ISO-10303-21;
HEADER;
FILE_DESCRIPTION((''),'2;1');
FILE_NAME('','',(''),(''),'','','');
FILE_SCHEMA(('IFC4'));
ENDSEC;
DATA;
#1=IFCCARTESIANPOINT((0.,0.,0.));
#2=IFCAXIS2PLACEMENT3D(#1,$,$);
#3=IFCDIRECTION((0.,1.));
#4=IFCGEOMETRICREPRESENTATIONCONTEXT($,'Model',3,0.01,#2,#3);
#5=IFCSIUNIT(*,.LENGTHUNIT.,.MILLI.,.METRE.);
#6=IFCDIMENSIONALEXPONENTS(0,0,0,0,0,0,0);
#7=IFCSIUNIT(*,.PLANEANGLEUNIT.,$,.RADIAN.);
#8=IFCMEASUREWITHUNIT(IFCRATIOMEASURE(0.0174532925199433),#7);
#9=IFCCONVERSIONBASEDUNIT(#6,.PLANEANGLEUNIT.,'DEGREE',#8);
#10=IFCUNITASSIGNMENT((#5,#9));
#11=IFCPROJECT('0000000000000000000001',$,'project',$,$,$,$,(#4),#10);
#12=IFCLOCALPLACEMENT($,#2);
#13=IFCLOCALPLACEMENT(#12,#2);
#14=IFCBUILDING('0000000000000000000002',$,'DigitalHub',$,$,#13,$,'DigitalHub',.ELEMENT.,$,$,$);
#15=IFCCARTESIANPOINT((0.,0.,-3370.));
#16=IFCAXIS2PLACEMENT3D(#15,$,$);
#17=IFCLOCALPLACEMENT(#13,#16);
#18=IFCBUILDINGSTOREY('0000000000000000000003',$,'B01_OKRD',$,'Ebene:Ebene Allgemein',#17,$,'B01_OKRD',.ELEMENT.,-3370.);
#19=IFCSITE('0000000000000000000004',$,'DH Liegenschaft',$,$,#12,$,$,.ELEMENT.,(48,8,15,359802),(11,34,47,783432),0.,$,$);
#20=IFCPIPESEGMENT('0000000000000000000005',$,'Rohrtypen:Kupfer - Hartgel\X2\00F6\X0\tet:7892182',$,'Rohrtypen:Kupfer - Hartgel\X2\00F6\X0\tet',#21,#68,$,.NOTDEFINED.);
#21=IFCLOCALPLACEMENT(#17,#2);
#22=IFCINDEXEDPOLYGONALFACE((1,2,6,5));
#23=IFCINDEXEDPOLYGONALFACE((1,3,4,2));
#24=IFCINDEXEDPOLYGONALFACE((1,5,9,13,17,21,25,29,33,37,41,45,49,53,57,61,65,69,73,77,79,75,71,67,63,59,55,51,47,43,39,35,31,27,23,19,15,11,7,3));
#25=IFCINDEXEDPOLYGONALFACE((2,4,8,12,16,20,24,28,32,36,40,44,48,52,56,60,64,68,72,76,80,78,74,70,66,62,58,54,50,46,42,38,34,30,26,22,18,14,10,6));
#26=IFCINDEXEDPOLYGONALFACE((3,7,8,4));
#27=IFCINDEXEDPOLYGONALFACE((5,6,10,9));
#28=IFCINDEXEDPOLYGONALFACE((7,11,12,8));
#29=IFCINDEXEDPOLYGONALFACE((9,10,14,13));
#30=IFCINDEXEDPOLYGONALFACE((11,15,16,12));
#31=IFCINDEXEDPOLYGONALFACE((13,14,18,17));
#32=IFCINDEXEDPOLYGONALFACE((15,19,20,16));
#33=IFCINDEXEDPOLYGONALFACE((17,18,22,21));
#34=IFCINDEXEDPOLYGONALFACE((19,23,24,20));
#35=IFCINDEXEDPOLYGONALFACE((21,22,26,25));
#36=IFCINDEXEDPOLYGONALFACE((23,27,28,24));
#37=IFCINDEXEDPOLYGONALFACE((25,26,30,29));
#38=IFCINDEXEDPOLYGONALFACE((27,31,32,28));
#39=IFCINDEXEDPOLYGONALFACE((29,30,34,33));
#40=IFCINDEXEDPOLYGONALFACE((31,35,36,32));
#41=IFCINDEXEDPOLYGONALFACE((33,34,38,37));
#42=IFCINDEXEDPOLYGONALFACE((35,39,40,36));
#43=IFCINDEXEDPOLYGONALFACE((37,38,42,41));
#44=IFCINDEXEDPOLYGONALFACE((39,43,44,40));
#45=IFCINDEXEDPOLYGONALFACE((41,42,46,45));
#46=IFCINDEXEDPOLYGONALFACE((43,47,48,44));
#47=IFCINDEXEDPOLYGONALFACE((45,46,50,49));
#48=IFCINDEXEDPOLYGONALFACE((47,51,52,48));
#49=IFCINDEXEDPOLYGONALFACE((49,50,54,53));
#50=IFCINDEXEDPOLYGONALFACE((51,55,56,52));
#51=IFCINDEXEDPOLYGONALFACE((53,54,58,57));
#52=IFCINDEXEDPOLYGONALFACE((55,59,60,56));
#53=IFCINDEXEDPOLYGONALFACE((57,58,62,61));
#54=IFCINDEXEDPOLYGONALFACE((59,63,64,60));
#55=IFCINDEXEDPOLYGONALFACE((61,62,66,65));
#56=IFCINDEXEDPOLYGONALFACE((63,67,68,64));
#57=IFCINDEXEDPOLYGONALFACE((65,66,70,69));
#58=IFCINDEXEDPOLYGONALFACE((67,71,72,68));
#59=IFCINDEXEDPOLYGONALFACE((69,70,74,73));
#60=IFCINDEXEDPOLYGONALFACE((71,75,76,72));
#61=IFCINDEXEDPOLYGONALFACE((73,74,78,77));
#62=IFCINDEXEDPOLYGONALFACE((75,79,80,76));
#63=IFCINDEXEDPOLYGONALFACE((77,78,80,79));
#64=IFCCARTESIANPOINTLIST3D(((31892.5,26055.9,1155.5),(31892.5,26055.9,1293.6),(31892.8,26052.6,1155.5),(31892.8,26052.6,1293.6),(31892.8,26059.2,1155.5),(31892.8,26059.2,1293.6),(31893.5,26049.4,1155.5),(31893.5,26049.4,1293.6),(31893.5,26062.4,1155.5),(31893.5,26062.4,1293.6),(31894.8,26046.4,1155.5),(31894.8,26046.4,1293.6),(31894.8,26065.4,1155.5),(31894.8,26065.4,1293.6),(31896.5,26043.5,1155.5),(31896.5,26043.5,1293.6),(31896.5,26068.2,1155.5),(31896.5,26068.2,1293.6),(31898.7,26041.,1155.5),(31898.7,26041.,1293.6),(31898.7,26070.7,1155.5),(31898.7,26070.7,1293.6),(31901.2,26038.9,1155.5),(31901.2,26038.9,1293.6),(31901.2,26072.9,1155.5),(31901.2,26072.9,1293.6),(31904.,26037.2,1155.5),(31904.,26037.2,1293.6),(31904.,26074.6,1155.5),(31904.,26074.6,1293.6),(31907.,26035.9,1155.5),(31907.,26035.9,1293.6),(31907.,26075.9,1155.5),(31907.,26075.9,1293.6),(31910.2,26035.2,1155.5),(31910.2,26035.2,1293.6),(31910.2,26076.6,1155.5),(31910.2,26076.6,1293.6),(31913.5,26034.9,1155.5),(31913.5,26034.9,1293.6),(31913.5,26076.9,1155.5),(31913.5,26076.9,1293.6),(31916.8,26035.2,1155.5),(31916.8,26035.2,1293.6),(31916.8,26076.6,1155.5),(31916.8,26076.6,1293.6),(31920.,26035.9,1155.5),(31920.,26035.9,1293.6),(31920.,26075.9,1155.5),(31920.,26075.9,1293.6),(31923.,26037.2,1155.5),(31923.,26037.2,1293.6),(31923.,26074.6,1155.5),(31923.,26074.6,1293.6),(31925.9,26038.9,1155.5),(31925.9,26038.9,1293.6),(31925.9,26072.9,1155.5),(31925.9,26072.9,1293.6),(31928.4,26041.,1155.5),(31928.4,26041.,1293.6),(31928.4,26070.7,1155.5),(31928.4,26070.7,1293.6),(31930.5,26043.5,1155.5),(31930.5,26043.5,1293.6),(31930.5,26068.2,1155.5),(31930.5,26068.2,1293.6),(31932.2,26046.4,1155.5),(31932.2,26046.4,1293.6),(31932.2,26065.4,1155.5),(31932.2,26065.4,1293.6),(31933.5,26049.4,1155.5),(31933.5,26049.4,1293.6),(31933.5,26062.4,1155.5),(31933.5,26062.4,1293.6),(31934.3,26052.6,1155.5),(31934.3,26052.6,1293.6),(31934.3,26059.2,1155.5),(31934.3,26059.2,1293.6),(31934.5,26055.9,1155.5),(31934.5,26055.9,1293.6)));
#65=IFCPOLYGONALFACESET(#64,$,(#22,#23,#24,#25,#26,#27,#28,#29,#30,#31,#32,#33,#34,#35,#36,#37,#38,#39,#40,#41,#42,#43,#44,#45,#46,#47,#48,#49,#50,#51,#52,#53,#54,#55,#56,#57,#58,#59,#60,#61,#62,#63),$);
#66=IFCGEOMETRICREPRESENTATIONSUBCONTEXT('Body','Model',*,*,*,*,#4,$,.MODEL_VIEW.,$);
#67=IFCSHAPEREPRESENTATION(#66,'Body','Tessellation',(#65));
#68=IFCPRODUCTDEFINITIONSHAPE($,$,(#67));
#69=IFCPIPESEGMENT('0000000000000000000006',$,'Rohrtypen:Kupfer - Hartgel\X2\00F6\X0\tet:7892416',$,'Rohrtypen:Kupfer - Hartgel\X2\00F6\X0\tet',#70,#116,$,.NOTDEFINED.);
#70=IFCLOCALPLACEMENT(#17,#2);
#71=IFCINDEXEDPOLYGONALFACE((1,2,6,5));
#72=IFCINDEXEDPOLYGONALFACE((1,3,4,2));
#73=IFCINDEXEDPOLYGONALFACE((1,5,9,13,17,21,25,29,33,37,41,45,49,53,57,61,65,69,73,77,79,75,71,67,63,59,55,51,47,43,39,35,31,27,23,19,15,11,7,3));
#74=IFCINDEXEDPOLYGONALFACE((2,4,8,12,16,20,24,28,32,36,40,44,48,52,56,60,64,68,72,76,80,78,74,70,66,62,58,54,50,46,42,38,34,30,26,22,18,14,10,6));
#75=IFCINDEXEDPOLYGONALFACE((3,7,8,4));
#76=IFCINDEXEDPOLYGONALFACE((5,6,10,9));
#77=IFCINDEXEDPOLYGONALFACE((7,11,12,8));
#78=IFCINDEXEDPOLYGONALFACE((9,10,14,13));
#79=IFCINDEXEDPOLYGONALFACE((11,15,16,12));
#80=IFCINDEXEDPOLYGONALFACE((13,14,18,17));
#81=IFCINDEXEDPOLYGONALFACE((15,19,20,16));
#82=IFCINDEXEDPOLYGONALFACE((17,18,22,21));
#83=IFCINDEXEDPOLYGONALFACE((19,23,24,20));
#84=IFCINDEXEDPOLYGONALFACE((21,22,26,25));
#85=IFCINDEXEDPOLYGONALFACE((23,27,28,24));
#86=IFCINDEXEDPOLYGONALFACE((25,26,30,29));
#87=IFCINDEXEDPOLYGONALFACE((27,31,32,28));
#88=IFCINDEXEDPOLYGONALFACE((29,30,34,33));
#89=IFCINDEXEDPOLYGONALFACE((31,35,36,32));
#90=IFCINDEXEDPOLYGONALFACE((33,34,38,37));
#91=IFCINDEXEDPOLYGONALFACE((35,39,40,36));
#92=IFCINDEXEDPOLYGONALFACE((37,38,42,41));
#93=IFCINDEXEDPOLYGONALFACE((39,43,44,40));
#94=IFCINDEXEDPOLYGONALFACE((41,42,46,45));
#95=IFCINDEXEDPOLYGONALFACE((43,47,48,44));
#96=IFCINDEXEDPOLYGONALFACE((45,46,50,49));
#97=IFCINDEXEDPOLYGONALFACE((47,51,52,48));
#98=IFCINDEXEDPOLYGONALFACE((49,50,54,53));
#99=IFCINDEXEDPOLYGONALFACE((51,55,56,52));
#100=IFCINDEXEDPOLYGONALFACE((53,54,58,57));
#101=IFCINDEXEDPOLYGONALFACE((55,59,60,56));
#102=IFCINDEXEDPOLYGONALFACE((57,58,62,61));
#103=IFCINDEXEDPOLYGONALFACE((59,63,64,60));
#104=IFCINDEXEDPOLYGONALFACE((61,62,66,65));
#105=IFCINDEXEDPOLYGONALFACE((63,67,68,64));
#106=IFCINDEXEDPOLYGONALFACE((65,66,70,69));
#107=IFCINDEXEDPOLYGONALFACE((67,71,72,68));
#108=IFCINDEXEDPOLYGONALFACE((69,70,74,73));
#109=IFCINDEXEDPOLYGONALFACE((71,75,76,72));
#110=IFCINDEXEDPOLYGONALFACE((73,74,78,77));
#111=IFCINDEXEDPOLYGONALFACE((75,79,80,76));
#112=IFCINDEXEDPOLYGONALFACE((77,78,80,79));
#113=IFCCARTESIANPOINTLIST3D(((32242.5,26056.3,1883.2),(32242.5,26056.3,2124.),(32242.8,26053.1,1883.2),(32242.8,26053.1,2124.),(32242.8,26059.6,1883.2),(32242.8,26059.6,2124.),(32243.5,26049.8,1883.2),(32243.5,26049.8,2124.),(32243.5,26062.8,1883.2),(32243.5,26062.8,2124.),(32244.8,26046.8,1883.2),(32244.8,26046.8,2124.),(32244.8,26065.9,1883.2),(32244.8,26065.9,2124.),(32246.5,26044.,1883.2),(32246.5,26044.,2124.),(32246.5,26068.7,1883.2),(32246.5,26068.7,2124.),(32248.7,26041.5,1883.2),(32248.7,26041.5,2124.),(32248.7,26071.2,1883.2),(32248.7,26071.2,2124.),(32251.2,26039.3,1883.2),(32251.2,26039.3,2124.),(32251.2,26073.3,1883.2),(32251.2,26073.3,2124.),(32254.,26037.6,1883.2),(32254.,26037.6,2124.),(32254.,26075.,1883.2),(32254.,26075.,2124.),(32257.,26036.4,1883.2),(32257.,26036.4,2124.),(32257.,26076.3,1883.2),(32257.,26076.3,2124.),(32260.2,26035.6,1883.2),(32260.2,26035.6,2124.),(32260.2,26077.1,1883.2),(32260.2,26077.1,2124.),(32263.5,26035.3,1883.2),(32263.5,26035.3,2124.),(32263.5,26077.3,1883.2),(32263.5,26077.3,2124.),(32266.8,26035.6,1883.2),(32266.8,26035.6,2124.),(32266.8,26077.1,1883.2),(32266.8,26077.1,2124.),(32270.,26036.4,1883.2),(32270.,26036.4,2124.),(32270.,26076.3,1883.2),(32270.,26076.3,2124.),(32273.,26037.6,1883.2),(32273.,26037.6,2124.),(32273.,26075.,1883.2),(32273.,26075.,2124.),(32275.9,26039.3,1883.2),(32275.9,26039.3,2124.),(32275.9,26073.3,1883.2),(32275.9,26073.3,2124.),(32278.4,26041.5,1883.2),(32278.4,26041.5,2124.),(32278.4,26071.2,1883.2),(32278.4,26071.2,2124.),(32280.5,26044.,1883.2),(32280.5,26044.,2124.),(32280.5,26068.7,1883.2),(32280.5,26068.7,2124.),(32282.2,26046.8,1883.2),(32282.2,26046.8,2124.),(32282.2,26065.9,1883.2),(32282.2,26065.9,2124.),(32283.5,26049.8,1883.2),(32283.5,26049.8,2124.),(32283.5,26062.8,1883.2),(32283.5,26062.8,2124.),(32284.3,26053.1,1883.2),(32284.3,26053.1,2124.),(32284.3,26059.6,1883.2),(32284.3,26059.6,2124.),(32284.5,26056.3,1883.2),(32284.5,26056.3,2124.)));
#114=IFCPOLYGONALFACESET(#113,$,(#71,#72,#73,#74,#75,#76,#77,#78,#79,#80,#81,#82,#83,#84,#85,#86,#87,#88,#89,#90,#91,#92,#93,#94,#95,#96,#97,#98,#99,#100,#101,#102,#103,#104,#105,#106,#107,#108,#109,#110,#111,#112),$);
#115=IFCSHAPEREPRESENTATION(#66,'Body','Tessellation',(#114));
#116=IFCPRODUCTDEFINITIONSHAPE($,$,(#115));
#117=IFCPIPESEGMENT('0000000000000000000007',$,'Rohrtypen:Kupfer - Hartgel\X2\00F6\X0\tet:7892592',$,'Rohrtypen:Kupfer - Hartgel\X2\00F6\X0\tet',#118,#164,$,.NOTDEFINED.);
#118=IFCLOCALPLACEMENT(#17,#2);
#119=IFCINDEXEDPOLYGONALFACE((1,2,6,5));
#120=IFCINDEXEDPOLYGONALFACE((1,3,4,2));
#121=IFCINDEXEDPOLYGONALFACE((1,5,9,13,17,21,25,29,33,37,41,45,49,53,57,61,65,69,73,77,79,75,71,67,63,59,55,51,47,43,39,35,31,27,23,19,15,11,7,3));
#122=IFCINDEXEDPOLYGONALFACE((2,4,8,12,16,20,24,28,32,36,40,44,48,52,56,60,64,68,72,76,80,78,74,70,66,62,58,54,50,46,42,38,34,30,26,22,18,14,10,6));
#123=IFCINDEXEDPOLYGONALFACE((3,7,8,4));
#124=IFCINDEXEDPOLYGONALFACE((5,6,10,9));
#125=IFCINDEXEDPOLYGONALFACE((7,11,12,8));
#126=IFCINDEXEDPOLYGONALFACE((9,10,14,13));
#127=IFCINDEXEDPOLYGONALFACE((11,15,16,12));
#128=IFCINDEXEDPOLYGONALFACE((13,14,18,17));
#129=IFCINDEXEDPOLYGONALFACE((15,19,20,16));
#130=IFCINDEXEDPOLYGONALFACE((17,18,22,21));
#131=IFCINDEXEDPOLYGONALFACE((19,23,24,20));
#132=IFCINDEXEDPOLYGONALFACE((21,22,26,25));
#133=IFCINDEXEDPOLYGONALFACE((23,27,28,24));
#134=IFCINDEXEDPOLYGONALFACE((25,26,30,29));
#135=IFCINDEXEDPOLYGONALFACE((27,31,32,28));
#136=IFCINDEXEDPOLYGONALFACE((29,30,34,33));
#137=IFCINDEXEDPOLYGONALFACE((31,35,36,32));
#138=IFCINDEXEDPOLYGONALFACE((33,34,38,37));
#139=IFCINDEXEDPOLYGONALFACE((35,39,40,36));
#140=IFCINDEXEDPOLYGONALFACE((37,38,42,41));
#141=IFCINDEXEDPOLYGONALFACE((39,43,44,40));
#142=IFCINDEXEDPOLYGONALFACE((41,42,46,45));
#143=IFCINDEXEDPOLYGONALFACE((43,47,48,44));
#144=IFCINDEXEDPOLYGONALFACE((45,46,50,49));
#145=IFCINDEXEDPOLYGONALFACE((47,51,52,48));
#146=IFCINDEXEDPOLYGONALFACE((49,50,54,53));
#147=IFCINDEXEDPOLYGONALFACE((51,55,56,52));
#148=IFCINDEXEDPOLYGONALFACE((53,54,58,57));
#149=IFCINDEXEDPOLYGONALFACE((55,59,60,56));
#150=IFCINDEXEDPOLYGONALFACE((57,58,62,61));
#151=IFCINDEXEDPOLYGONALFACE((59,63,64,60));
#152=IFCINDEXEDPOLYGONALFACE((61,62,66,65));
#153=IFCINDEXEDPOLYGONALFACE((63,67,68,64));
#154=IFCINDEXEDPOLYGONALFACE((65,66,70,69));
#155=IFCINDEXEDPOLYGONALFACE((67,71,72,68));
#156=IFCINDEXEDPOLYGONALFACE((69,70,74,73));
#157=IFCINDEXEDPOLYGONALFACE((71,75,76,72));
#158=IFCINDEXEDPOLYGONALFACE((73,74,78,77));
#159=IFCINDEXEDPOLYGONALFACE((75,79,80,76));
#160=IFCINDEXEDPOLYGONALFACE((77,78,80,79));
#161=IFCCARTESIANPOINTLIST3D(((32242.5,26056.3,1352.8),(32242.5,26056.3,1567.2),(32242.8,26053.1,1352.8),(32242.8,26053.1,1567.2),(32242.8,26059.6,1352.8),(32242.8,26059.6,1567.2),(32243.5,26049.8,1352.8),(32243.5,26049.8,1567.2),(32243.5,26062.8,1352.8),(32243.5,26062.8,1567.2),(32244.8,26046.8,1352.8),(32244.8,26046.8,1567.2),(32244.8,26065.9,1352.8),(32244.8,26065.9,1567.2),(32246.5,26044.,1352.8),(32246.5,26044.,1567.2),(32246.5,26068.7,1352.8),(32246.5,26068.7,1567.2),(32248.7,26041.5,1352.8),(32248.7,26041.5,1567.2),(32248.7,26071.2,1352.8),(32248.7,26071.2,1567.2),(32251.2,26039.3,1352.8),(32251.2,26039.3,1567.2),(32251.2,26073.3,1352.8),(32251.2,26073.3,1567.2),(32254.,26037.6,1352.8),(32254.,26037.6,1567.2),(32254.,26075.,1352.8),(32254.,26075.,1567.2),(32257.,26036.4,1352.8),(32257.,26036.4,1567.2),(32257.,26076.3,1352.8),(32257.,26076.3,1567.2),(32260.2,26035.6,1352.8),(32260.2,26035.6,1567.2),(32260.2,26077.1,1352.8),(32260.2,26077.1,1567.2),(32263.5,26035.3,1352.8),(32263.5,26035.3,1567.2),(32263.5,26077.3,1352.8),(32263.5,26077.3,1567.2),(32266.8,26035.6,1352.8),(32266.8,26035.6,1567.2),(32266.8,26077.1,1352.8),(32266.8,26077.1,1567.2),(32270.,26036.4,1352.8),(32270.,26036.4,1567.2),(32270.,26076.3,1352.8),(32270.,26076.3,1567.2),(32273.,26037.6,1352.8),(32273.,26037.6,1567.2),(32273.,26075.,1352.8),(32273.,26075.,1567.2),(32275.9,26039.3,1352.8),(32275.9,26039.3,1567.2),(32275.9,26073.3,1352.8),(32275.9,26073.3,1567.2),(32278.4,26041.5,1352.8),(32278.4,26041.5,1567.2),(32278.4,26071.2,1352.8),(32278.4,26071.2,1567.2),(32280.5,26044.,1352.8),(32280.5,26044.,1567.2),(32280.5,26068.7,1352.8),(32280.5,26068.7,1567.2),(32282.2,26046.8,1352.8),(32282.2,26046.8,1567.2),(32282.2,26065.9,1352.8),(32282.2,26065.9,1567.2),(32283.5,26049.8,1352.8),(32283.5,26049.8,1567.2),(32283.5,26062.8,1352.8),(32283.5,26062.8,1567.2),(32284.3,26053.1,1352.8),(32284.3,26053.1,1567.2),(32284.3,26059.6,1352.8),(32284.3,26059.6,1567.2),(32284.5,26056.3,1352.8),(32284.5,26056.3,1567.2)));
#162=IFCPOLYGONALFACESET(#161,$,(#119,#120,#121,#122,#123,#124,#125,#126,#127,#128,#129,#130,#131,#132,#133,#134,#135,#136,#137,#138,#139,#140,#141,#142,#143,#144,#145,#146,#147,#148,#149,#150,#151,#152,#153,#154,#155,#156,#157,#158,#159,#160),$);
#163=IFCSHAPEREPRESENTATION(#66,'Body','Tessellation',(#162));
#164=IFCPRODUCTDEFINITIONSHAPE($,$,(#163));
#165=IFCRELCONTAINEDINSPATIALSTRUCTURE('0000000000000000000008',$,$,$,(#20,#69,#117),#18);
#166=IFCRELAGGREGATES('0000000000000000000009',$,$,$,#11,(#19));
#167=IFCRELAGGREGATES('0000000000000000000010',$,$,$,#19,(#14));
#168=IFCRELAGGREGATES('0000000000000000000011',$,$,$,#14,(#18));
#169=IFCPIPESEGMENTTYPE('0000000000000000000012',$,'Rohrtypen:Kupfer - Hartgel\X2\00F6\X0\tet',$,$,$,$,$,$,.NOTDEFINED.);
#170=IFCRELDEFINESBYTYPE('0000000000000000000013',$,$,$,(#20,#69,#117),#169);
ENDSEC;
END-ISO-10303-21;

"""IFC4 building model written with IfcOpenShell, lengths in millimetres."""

from ifc_helpers import new_model, entity, si_unit, converted_unit, direction, frame, origin, place, context, subcontext, project, spatial, indexed_curve, outline, extrude, type_object, element, save


model = new_model("IFC4")

# Units and contexts
model_context = context("Model", 3, precision=0.01, world=origin(), true_north=direction((0.0, 1.0)))
body_context = subcontext(model_context, "Body", "Model", "MODEL_VIEW")
ifc_project = project(units=[si_unit("LENGTHUNIT", "METRE", prefix="MILLI"), converted_unit("PLANEANGLEUNIT", "DEGREE", entity("IfcRatioMeasure", 0.0174532925199433), si_unit("PLANEANGLEUNIT", "RADIAN"), dimensions=[0, 0, 0, 0, 0, 0, 0])], contexts=[model_context])

# Site, building, storey
site_placement = place(None, origin())
site = spatial("IfcSite", under=ifc_project, at=site_placement, Name="DH Liegenschaft", CompositionType="ELEMENT", RefLatitude=(48, 8, 15, 359802), RefLongitude=(11, 34, 47, 783432), RefElevation=0.0)
building_placement = place(site_placement, origin())
building = spatial("IfcBuilding", under=site, at=building_placement, Name="DigitalHub", LongName="DigitalHub", CompositionType="ELEMENT")
storey_placement = place(building_placement, frame((0.0, 0.0, -3370.0)))
storey = spatial("IfcBuildingStorey", under=building, at=storey_placement, Name="B01_OKRD", ObjectType="Ebene:Ebene Allgemein", LongName="B01_OKRD", CompositionType="ELEMENT", Elevation=-3370.0)

# Pipe segments
pipe_segment_type = type_object("IfcPipeSegmentType", Name="Rohrtypen:Kupfer - Hartgelötet", PredefinedType="NOTDEFINED")
pipe_segment_1_placement = place(storey_placement, frame((31890.9, 26033.3, 1155.5)))
element("IfcPipeSegment", 1, at=pipe_segment_1_placement, inside=storey, type_object=pipe_segment_type, Name="Rohrtypen:Kupfer - Hartgelötet:7892182", ObjectType="Rohrtypen:Kupfer - Hartgelötet", PredefinedType="NOTDEFINED", context=body_context, shape_type="SweptSolid", body=[
    extrude(outline(indexed_curve([(21.0, 0.0), (20.7, 3.3), (20.0, 6.5), (18.7, 9.5), (17.0, 12.3), (14.8, 14.8), (12.3, 17.0), (9.5, 18.7), (6.5, 20.0), (3.3, 20.7), (0.0, 21.0), (-3.3, 20.7), (-6.5, 20.0), (-9.5, 18.7), (-12.3, 17.0), (-14.8, 14.8), (-17.0, 12.3), (-18.7, 9.5), (-20.0, 6.5), (-20.7, 3.3), (-21.0, 0.0), (-20.7, -3.3), (-20.0, -6.5), (-18.7, -9.5), (-17.0, -12.3), (-14.8, -14.8), (-12.3, -17.0), (-9.5, -18.7), (-6.5, -20.0), (-3.3, -20.7), (0.0, -21.0), (3.3, -20.7), (6.5, -20.0), (9.5, -18.7), (12.3, -17.0), (14.8, -14.8), (17.0, -12.3), (18.7, -9.5), (20.0, -6.5), (20.7, -3.3), (21.0, 0.0)], self_intersect=False)), frame((22.6, 22.6, 0.0), z_axis=(0.0, 0.0, 1.0), x_axis=(-1.0, 0.0, 0.0)), (0.0, 0.0, 1.0), 138.1),
])
pipe_segment_2_placement = place(storey_placement, frame((32240.9, 26033.7, 1883.2)))
element("IfcPipeSegment", 2, at=pipe_segment_2_placement, inside=storey, type_object=pipe_segment_type, Name="Rohrtypen:Kupfer - Hartgelötet:7892416", ObjectType="Rohrtypen:Kupfer - Hartgelötet", PredefinedType="NOTDEFINED", context=body_context, shape_type="SweptSolid", body=[
    extrude(outline(indexed_curve([(21.0, 0.0), (20.7, 3.3), (20.0, 6.5), (18.7, 9.5), (17.0, 12.3), (14.8, 14.8), (12.3, 17.0), (9.5, 18.7), (6.5, 20.0), (3.3, 20.7), (0.0, 21.0), (-3.3, 20.7), (-6.5, 20.0), (-9.5, 18.7), (-12.3, 17.0), (-14.8, 14.8), (-17.0, 12.3), (-18.7, 9.5), (-20.0, 6.5), (-20.7, 3.3), (-21.0, 0.0), (-20.7, -3.3), (-20.0, -6.5), (-18.7, -9.5), (-17.0, -12.3), (-14.8, -14.8), (-12.3, -17.0), (-9.5, -18.7), (-6.5, -20.0), (-3.3, -20.7), (0.0, -21.0), (3.3, -20.7), (6.5, -20.0), (9.5, -18.7), (12.3, -17.0), (14.8, -14.8), (17.0, -12.3), (18.7, -9.5), (20.0, -6.5), (20.7, -3.3), (21.0, 0.0)], self_intersect=False)), frame((22.6, 22.6, 0.0)), (0.0, 0.0, 1.0), 240.8),
])
pipe_segment_3_placement = place(storey_placement, frame((32240.9, 26033.7, 1352.8)))
element("IfcPipeSegment", 3, at=pipe_segment_3_placement, inside=storey, type_object=pipe_segment_type, Name="Rohrtypen:Kupfer - Hartgelötet:7892592", ObjectType="Rohrtypen:Kupfer - Hartgelötet", PredefinedType="NOTDEFINED", context=body_context, shape_type="SweptSolid", body=[
    extrude(outline(indexed_curve([(21.0, 0.0), (20.7, 3.3), (20.0, 6.5), (18.7, 9.5), (17.0, 12.3), (14.8, 14.8), (12.3, 17.0), (9.5, 18.7), (6.5, 20.0), (3.3, 20.7), (0.0, 21.0), (-3.3, 20.7), (-6.5, 20.0), (-9.5, 18.7), (-12.3, 17.0), (-14.8, 14.8), (-17.0, 12.3), (-18.7, 9.5), (-20.0, 6.5), (-20.7, 3.3), (-21.0, 0.0), (-20.7, -3.3), (-20.0, -6.5), (-18.7, -9.5), (-17.0, -12.3), (-14.8, -14.8), (-12.3, -17.0), (-9.5, -18.7), (-6.5, -20.0), (-3.3, -20.7), (0.0, -21.0), (3.3, -20.7), (6.5, -20.0), (9.5, -18.7), (12.3, -17.0), (14.8, -14.8), (17.0, -12.3), (18.7, -9.5), (20.0, -6.5), (20.7, -3.3), (21.0, 0.0)], self_intersect=False)), frame((22.6, 22.6, 0.0), z_axis=(0.0, 0.0, 1.0), x_axis=(-1.0, 0.0, 0.0)), (0.0, 0.0, 1.0), 214.4),
])

save(model, "model.ifc")
